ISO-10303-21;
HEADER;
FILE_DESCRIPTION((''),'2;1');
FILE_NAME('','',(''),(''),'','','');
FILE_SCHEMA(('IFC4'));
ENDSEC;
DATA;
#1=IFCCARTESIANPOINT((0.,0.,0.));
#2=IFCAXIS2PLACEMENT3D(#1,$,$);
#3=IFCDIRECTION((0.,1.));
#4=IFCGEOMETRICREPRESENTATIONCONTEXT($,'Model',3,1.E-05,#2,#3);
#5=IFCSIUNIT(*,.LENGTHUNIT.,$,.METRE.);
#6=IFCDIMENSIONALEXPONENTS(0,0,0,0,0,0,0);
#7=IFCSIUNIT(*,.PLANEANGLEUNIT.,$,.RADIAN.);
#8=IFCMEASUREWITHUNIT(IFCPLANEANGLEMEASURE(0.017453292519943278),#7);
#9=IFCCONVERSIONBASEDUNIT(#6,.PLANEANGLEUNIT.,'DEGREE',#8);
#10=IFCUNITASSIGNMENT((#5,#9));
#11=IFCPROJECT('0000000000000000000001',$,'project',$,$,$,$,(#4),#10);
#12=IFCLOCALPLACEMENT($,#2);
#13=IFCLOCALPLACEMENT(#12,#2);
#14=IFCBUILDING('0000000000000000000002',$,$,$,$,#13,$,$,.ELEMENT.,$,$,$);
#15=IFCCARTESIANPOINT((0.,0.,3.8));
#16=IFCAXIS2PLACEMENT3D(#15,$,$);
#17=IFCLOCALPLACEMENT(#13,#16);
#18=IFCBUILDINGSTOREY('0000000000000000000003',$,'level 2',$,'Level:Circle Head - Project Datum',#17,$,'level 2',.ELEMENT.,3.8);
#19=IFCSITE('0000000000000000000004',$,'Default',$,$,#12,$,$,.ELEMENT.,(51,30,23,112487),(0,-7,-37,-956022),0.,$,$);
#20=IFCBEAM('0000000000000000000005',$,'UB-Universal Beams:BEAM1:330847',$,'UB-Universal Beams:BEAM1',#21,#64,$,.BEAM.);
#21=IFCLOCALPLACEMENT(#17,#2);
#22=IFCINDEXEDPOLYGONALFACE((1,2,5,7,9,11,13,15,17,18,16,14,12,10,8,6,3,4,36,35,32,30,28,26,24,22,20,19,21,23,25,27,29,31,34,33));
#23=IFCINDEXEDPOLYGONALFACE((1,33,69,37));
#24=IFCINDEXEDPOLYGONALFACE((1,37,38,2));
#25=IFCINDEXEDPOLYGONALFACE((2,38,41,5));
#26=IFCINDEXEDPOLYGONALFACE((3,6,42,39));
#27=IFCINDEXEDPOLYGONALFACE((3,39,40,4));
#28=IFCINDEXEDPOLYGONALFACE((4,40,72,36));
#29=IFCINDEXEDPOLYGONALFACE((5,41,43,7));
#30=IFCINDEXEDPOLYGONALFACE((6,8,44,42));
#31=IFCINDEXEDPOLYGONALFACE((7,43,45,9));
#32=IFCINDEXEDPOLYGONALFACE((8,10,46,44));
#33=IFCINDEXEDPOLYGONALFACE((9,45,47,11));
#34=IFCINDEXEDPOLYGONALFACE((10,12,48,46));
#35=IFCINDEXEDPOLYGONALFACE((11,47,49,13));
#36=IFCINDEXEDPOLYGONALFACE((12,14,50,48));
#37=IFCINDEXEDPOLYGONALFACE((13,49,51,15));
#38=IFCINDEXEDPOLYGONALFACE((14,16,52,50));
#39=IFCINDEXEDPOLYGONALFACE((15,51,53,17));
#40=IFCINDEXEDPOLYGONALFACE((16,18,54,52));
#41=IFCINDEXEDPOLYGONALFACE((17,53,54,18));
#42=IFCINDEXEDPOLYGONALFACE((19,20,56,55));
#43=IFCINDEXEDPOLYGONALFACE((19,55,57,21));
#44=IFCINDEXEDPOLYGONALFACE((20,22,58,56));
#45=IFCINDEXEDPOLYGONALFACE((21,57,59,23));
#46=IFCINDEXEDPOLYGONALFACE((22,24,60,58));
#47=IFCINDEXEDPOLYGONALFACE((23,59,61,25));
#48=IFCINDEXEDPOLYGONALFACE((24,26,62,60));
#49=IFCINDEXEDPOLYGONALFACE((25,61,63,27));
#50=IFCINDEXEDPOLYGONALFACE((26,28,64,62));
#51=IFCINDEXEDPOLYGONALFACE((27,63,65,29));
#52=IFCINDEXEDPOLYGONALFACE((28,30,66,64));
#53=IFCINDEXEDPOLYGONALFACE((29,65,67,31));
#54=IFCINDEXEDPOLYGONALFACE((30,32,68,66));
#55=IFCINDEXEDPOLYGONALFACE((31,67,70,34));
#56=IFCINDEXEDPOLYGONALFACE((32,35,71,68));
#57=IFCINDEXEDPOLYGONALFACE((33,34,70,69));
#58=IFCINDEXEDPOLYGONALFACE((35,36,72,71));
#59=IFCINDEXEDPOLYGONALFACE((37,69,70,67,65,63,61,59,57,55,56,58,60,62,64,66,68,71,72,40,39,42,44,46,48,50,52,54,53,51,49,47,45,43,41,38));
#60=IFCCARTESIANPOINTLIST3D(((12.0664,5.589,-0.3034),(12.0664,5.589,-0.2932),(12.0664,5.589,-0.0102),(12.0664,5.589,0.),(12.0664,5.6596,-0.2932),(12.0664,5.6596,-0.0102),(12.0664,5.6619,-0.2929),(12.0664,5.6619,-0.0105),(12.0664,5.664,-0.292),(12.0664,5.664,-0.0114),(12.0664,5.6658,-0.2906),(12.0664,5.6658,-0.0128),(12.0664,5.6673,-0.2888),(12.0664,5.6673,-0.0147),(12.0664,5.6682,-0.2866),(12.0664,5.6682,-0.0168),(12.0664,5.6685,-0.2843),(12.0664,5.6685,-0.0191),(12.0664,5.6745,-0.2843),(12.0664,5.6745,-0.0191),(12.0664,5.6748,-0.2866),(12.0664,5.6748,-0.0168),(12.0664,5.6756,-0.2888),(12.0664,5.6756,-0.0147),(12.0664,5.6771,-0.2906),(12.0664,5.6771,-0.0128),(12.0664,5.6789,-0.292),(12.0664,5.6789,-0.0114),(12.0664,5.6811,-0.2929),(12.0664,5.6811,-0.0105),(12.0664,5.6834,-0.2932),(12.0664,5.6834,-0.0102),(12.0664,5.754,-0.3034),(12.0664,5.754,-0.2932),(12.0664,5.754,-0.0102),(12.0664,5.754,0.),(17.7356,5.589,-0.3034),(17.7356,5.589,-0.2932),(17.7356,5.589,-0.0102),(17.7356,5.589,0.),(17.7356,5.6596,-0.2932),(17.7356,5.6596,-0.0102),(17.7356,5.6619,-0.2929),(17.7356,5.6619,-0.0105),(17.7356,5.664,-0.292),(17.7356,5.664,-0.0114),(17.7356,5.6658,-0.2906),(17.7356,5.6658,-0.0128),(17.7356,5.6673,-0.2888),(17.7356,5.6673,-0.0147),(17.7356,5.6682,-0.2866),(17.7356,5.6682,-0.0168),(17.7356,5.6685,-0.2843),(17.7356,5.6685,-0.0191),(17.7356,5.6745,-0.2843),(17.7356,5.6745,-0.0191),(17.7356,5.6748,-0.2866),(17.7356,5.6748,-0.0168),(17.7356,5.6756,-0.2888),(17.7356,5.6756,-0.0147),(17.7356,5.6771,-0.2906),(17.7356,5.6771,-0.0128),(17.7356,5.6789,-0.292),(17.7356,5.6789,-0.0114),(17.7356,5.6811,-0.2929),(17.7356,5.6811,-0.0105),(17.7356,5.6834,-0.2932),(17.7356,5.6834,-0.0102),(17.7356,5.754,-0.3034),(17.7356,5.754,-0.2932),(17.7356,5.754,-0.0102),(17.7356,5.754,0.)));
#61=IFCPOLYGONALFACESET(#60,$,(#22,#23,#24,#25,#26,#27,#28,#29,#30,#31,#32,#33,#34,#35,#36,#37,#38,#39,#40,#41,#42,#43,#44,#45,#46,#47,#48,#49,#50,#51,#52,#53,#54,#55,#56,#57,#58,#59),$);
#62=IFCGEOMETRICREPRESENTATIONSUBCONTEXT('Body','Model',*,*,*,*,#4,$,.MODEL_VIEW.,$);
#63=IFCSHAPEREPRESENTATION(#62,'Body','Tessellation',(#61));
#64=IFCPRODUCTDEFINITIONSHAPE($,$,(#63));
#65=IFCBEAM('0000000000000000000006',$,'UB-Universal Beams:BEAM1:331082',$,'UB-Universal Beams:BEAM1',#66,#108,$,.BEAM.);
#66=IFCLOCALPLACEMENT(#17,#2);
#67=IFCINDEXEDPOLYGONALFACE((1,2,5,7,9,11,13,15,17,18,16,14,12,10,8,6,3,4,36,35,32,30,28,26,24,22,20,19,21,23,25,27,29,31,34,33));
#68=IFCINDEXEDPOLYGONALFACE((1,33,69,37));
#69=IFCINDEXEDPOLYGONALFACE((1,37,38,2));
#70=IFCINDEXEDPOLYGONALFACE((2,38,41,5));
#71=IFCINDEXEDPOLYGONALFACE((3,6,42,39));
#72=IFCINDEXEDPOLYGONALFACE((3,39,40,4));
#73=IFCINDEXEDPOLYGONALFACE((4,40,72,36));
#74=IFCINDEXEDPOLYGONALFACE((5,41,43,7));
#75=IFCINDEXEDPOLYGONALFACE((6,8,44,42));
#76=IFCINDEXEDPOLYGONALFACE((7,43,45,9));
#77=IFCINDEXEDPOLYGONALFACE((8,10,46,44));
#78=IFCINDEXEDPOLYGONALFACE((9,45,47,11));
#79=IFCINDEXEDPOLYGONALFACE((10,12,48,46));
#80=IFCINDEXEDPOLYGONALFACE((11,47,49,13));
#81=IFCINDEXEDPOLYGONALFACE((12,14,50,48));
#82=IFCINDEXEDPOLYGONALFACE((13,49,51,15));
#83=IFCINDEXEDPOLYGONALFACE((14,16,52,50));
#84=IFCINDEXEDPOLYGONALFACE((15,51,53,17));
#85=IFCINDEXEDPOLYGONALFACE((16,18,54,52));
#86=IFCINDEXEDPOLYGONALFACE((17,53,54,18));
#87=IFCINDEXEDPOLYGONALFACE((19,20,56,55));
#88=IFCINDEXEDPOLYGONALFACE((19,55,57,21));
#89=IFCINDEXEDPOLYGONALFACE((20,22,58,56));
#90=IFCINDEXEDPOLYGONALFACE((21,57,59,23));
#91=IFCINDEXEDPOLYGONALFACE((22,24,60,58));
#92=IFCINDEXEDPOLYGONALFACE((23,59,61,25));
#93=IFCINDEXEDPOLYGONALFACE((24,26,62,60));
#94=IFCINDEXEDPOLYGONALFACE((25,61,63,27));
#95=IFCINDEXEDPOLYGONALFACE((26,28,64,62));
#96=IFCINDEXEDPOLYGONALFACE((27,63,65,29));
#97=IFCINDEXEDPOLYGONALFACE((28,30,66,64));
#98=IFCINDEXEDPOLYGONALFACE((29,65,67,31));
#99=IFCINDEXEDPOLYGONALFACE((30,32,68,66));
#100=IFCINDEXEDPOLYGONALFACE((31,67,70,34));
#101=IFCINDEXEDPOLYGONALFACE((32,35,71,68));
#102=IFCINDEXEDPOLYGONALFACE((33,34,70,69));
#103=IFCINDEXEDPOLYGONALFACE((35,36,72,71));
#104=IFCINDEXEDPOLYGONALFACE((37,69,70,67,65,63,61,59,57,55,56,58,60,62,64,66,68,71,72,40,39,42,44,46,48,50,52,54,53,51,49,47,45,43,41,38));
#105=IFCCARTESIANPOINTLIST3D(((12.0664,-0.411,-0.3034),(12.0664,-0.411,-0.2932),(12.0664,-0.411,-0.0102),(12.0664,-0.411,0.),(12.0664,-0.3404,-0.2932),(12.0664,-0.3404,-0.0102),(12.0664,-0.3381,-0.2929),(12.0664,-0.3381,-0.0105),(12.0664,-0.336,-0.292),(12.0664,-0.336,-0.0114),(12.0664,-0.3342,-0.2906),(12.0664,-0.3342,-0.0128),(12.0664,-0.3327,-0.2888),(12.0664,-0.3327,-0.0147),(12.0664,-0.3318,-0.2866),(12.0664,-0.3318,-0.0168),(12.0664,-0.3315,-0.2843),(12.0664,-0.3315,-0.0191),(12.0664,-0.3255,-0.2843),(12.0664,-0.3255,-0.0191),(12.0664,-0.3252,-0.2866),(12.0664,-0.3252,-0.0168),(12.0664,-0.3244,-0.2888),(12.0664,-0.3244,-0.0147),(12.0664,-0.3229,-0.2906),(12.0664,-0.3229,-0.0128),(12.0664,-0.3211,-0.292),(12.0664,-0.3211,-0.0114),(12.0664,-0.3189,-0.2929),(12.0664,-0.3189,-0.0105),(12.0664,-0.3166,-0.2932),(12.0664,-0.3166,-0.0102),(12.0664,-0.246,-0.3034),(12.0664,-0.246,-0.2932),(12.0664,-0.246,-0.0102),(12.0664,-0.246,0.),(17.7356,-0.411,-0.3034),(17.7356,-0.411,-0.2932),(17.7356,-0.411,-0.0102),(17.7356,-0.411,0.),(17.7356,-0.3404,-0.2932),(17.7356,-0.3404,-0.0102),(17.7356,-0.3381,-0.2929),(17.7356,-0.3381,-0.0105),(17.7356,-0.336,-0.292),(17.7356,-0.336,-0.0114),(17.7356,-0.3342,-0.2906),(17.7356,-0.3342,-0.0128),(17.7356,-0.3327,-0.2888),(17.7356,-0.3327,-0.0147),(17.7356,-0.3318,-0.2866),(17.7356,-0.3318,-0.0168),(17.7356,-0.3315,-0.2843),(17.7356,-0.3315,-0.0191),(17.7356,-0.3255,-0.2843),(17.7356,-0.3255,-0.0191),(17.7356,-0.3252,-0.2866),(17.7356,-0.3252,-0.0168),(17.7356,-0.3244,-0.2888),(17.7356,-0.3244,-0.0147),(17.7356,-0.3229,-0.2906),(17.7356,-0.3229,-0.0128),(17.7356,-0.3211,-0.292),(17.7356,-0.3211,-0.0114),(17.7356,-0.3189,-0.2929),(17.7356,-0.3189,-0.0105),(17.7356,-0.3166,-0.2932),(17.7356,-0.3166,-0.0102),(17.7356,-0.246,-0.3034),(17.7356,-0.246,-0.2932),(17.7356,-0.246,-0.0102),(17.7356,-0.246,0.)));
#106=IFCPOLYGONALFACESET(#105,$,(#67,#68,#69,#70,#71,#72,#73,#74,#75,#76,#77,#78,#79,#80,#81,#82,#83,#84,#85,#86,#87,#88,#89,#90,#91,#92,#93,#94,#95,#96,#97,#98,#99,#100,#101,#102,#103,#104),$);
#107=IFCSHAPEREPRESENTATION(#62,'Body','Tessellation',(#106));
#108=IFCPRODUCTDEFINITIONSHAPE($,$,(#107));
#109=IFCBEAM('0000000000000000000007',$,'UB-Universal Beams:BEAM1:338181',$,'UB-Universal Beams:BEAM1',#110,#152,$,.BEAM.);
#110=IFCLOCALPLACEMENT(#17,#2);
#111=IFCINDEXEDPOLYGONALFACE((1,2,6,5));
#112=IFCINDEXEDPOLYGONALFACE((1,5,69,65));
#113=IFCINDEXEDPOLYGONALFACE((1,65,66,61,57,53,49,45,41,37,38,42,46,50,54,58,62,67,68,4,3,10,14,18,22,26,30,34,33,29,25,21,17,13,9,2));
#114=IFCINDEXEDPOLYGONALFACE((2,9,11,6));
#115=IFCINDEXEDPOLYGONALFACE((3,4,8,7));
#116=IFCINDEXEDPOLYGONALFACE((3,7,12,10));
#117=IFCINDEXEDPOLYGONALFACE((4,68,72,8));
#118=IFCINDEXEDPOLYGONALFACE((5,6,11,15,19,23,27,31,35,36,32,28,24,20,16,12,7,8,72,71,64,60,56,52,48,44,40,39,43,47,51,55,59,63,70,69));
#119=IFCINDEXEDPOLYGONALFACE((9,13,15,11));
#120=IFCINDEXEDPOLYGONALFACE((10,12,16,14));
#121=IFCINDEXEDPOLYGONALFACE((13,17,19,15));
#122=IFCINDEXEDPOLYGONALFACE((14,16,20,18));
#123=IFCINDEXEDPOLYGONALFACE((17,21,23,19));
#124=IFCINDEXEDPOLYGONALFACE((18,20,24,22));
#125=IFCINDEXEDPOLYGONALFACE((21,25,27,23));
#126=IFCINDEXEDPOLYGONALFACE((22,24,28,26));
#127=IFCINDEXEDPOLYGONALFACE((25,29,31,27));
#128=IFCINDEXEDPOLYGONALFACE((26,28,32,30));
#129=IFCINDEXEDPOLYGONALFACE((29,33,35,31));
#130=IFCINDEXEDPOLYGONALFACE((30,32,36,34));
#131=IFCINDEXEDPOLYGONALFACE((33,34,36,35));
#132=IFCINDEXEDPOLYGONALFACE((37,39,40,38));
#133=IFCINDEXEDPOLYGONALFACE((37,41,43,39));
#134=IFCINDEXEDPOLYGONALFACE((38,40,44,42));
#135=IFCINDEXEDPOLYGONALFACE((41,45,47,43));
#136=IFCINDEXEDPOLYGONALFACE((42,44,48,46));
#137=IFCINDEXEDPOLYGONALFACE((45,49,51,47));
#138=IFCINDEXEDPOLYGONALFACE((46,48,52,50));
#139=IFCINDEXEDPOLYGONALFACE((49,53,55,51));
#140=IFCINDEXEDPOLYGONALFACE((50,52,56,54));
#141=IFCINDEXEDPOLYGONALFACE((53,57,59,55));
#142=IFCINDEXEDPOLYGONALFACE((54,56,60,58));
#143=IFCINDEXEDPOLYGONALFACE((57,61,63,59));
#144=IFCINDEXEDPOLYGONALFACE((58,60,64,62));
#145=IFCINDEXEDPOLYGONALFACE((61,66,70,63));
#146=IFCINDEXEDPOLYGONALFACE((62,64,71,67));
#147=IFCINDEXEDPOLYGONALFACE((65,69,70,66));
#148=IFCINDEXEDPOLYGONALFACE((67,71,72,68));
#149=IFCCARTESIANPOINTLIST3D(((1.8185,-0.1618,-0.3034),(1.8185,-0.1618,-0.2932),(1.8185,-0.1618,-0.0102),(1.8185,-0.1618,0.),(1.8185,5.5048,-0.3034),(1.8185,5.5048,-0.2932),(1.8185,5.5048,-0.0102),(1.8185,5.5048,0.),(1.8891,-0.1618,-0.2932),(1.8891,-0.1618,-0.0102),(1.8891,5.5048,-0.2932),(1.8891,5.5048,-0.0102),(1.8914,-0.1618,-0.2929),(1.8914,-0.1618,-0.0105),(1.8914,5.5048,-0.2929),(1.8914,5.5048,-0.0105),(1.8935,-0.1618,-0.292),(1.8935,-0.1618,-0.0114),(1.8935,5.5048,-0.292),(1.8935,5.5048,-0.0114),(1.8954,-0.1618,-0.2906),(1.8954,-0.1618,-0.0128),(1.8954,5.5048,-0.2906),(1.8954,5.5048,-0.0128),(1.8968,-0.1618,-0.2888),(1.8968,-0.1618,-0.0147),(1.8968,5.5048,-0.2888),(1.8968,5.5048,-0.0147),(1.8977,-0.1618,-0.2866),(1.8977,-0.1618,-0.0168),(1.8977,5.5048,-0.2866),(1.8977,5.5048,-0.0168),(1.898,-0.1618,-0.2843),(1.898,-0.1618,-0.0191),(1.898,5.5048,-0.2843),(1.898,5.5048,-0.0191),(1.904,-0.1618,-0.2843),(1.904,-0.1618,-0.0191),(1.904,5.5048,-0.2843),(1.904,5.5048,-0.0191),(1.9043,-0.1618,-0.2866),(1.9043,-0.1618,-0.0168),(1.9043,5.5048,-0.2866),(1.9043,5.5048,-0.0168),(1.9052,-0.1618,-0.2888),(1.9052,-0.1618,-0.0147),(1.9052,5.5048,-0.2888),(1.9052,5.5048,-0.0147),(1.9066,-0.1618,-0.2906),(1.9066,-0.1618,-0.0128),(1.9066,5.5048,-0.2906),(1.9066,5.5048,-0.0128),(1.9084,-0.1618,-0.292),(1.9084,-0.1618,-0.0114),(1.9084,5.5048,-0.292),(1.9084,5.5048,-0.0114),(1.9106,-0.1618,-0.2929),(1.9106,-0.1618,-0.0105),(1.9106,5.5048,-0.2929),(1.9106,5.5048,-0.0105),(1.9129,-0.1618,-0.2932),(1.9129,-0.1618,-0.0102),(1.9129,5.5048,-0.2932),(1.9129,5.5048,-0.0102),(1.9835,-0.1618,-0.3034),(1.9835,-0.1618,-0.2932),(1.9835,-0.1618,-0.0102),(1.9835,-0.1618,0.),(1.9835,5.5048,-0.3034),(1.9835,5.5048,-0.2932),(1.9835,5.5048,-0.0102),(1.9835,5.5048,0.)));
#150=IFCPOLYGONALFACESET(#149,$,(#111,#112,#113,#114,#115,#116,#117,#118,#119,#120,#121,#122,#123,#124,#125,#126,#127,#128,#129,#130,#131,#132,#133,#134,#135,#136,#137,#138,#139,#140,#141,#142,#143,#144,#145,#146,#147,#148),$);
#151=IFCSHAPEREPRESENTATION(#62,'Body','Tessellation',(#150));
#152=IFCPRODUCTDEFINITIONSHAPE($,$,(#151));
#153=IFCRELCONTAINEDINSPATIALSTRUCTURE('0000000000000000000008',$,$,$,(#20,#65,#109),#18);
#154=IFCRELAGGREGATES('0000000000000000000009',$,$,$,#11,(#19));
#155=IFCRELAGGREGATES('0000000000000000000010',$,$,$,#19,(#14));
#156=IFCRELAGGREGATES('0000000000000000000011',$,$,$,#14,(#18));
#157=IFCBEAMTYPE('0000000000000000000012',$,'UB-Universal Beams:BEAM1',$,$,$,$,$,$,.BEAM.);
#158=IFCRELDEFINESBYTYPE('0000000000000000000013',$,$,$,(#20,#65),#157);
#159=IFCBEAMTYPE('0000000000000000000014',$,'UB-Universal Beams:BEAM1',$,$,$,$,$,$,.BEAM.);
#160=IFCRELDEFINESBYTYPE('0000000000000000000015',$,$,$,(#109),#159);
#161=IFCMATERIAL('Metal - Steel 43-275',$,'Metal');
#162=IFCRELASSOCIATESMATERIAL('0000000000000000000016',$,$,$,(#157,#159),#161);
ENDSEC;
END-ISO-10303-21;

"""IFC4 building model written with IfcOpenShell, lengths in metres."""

from ifc_helpers import new_model, entity, si_unit, converted_unit, direction, frame, frame_2d, origin, place, context, subcontext, project, spatial, polyline, circle_curve, parameter, trimmed, segment, composite_curve, outline, extrude, source, transform, mapped, material, material_profile, profile_set, type_object, type_shapes, element, save


model = new_model("IFC4")

# Units and contexts
model_context = context("Model", 3, precision=1e-05, world=origin(), true_north=direction((0.0, 1.0)))
body_context = subcontext(model_context, "Body", "Model", "MODEL_VIEW")
ifc_project = project(units=[si_unit("LENGTHUNIT", "METRE"), converted_unit("PLANEANGLEUNIT", "DEGREE", entity("IfcPlaneAngleMeasure", 0.017453292519943278), si_unit("PLANEANGLEUNIT", "RADIAN"), dimensions=[0, 0, 0, 0, 0, 0, 0])], contexts=[model_context])

# Site, building, storey
site_placement = place(None, origin())
site = spatial("IfcSite", under=ifc_project, at=site_placement, Name="Default", CompositionType="ELEMENT", RefLatitude=(51, 30, 23, 112487), RefLongitude=(0, -7, -37, -956022), RefElevation=0.0)
building_placement = place(site_placement, origin())
building = spatial("IfcBuilding", under=site, at=building_placement, CompositionType="ELEMENT")
storey_placement = place(building_placement, frame((0.0, 0.0, 3.8)))
storey = spatial("IfcBuildingStorey", under=building, at=storey_placement, Name="level 2", ObjectType="Level:Circle Head - Project Datum", LongName="level 2", CompositionType="ELEMENT", Elevation=3.8)

# Shared definitions
ifc_material_1 = material(Name="Metal - Steel 43-275", Category="Metal")

# Beams
ifc_material_profile_1 = material_profile(ifc_material_1, outline(composite_curve([segment(polyline([(-0.0825, -0.1415), (-0.0825, -0.1517)]), True, "CONTINUOUS"), segment(polyline([(-0.0825, -0.1517), (0.0825, -0.1517)]), True, "CONTINUOUS"), segment(polyline([(0.0825, -0.1517), (0.0825, -0.1415)]), True, "CONTINUOUS"), segment(polyline([(0.0825, -0.1415), (0.0119, -0.1415)]), True, "CONTINUOUS"), segment(trimmed(circle_curve(frame_2d((0.0119, -0.1326), x_axis=(1.0, 0.0)), 0.0089), [parameter(180.0)], [parameter(270.0)], True, "PARAMETER"), False, "CONTINUOUS"), segment(polyline([(0.003, -0.1326), (0.003, 0.1326)]), True, "CONTINUOUS"), segment(trimmed(circle_curve(frame_2d((0.0119, 0.1326), x_axis=(1.0, 0.0)), 0.0089), [parameter(90.0)], [parameter(180.0)], True, "PARAMETER"), False, "CONTINUOUS"), segment(polyline([(0.0119, 0.1415), (0.0825, 0.1415)]), True, "CONTINUOUS"), segment(polyline([(0.0825, 0.1415), (0.0825, 0.1517)]), True, "CONTINUOUS"), segment(polyline([(0.0825, 0.1517), (-0.0825, 0.1517)]), True, "CONTINUOUS"), segment(polyline([(-0.0825, 0.1517), (-0.0825, 0.1415)]), True, "CONTINUOUS"), segment(polyline([(-0.0825, 0.1415), (-0.0119, 0.1415)]), True, "CONTINUOUS"), segment(trimmed(circle_curve(frame_2d((-0.0119, 0.1326), x_axis=(1.0, 0.0)), 0.0089), [parameter(360.0)], [parameter(90.0)], True, "PARAMETER"), False, "CONTINUOUS"), segment(polyline([(-0.003, 0.1326), (-0.003, -0.1326)]), True, "CONTINUOUS"), segment(trimmed(circle_curve(frame_2d((-0.0119, -0.1326), x_axis=(1.0, 0.0)), 0.0089), [parameter(270.0)], [parameter(360.0)], True, "PARAMETER"), False, "CONTINUOUS"), segment(polyline([(-0.0119, -0.1415), (-0.0825, -0.1415)]), True, "CONTINUOUS")], self_intersect=False)), Name="BEAM1")
ifc_profile_set_1 = profile_set([ifc_material_profile_1], Name="BEAM1")
beam_type_1 = type_object("IfcBeamType", Name="UB-Universal Beams:BEAM1", PredefinedType="BEAM", material=ifc_profile_set_1)
shared_shape_1 = source(origin(), body_context, "Body", "SweptSolid", [
    extrude(outline(composite_curve([segment(polyline([(-0.0825, -0.1415), (-0.0825, -0.1517)]), True, "CONTINUOUS"), segment(polyline([(-0.0825, -0.1517), (0.0825, -0.1517)]), True, "CONTINUOUS"), segment(polyline([(0.0825, -0.1517), (0.0825, -0.1415)]), True, "CONTINUOUS"), segment(polyline([(0.0825, -0.1415), (0.0119, -0.1415)]), True, "CONTINUOUS"), segment(trimmed(circle_curve(frame_2d((0.0119, -0.1326), x_axis=(0.0, -1.0)), 0.0089), [parameter(270.0)], [parameter(360.0)], True, "PARAMETER"), False, "CONTINUOUS"), segment(polyline([(0.003, -0.1326), (0.003, 0.1326)]), True, "CONTINUOUS"), segment(trimmed(circle_curve(frame_2d((0.0119, 0.1326), x_axis=(-1.0, 0.0)), 0.0089), [parameter(270.0)], [parameter(360.0)], True, "PARAMETER"), False, "CONTINUOUS"), segment(polyline([(0.0119, 0.1415), (0.0825, 0.1415)]), True, "CONTINUOUS"), segment(polyline([(0.0825, 0.1415), (0.0825, 0.1517)]), True, "CONTINUOUS"), segment(polyline([(0.0825, 0.1517), (-0.0825, 0.1517)]), True, "CONTINUOUS"), segment(polyline([(-0.0825, 0.1517), (-0.0825, 0.1415)]), True, "CONTINUOUS"), segment(polyline([(-0.0825, 0.1415), (-0.0119, 0.1415)]), True, "CONTINUOUS"), segment(trimmed(circle_curve(frame_2d((-0.0119, 0.1326), x_axis=(0.0, 1.0)), 0.0089), [parameter(270.0)], [parameter(360.0)], True, "PARAMETER"), False, "CONTINUOUS"), segment(polyline([(-0.003, 0.1326), (-0.003, -0.1326)]), True, "CONTINUOUS"), segment(trimmed(circle_curve(frame_2d((-0.0119, -0.1326), x_axis=(1.0, 0.0)), 0.0089), [parameter(270.0)], [parameter(0.0)], True, "PARAMETER"), False, "CONTINUOUS"), segment(polyline([(-0.0119, -0.1415), (-0.0825, -0.1415)]), True, "CONTINUOUS")], self_intersect=False)), frame((-2.8346, 0.0, 0.0), z_axis=(-1.0, 0.0, 0.0), x_axis=(0.0, -1.0, 0.0)), (0.0, 0.0, -1.0), 5.6692),
])
type_shapes(beam_type_1, [shared_shape_1])
for number, where, name in (
    (1, (14.901, 5.6715, -0.1517), "UB-Universal Beams:BEAM1:330847"),
    (2, (14.901, -0.3285, -0.1517), "UB-Universal Beams:BEAM1:331082"),
):
    element("IfcBeam", number, at=place(storey_placement, frame(where)), inside=storey, type_object=beam_type_1, Name=name, ObjectType="UB-Universal Beams:BEAM1", PredefinedType="BEAM", context=body_context, shape_type="MappedRepresentation", body=[
        mapped(shared_shape_1, transform((0.0, 0.0, 0.0), scale=1.0)),
    ])
beam_type_2 = type_object("IfcBeamType", Name="UB-Universal Beams:BEAM1", PredefinedType="BEAM", material=ifc_profile_set_1)
shared_shape_2 = source(origin(), body_context, "Body", "SweptSolid", [
    extrude(outline(composite_curve([segment(polyline([(-0.0825, -0.1415), (-0.0825, -0.1517)]), True, "CONTINUOUS"), segment(polyline([(-0.0825, -0.1517), (0.0825, -0.1517)]), True, "CONTINUOUS"), segment(polyline([(0.0825, -0.1517), (0.0825, -0.1415)]), True, "CONTINUOUS"), segment(polyline([(0.0825, -0.1415), (0.0119, -0.1415)]), True, "CONTINUOUS"), segment(trimmed(circle_curve(frame_2d((0.0119, -0.1326), x_axis=(1.0, 0.0)), 0.0089), [parameter(180.0)], [parameter(270.0)], True, "PARAMETER"), False, "CONTINUOUS"), segment(polyline([(0.003, -0.1326), (0.003, 0.1326)]), True, "CONTINUOUS"), segment(trimmed(circle_curve(frame_2d((0.0119, 0.1326), x_axis=(1.0, 0.0)), 0.0089), [parameter(90.0)], [parameter(180.0)], True, "PARAMETER"), False, "CONTINUOUS"), segment(polyline([(0.0119, 0.1415), (0.0825, 0.1415)]), True, "CONTINUOUS"), segment(polyline([(0.0825, 0.1415), (0.0825, 0.1517)]), True, "CONTINUOUS"), segment(polyline([(0.0825, 0.1517), (-0.0825, 0.1517)]), True, "CONTINUOUS"), segment(polyline([(-0.0825, 0.1517), (-0.0825, 0.1415)]), True, "CONTINUOUS"), segment(polyline([(-0.0825, 0.1415), (-0.0119, 0.1415)]), True, "CONTINUOUS"), segment(trimmed(circle_curve(frame_2d((-0.0119, 0.1326), x_axis=(1.0, 0.0)), 0.0089), [parameter(360.0)], [parameter(90.0)], True, "PARAMETER"), False, "CONTINUOUS"), segment(polyline([(-0.003, 0.1326), (-0.003, -0.1326)]), True, "CONTINUOUS"), segment(trimmed(circle_curve(frame_2d((-0.0119, -0.1326), x_axis=(1.0, 0.0)), 0.0089), [parameter(270.0)], [parameter(360.0)], True, "PARAMETER"), False, "CONTINUOUS"), segment(polyline([(-0.0119, -0.1415), (-0.0825, -0.1415)]), True, "CONTINUOUS")], self_intersect=False)), frame((-2.8333, 0.0, 0.0), z_axis=(-1.0, 0.0, 0.0), x_axis=(0.0, -1.0, 0.0)), (0.0, 0.0, -1.0), 5.6666),
])
type_shapes(beam_type_2, [shared_shape_2])
for number, where, z_axis, x_axis, name in (
    (3, (1.901, 2.6715, -0.1517), (0.0, 0.0, 1.0), (0.0, -1.0, 0.0), "UB-Universal Beams:BEAM1:338181"),
):
    element("IfcBeam", number, at=place(storey_placement, frame(where, z_axis=z_axis, x_axis=x_axis)), inside=storey, type_object=beam_type_2, Name=name, ObjectType="UB-Universal Beams:BEAM1", PredefinedType="BEAM", context=body_context, shape_type="MappedRepresentation", body=[
        mapped(shared_shape_2, transform((0.0, 0.0, 0.0), scale=1.0)),
    ])

save(model, "model.ifc")
